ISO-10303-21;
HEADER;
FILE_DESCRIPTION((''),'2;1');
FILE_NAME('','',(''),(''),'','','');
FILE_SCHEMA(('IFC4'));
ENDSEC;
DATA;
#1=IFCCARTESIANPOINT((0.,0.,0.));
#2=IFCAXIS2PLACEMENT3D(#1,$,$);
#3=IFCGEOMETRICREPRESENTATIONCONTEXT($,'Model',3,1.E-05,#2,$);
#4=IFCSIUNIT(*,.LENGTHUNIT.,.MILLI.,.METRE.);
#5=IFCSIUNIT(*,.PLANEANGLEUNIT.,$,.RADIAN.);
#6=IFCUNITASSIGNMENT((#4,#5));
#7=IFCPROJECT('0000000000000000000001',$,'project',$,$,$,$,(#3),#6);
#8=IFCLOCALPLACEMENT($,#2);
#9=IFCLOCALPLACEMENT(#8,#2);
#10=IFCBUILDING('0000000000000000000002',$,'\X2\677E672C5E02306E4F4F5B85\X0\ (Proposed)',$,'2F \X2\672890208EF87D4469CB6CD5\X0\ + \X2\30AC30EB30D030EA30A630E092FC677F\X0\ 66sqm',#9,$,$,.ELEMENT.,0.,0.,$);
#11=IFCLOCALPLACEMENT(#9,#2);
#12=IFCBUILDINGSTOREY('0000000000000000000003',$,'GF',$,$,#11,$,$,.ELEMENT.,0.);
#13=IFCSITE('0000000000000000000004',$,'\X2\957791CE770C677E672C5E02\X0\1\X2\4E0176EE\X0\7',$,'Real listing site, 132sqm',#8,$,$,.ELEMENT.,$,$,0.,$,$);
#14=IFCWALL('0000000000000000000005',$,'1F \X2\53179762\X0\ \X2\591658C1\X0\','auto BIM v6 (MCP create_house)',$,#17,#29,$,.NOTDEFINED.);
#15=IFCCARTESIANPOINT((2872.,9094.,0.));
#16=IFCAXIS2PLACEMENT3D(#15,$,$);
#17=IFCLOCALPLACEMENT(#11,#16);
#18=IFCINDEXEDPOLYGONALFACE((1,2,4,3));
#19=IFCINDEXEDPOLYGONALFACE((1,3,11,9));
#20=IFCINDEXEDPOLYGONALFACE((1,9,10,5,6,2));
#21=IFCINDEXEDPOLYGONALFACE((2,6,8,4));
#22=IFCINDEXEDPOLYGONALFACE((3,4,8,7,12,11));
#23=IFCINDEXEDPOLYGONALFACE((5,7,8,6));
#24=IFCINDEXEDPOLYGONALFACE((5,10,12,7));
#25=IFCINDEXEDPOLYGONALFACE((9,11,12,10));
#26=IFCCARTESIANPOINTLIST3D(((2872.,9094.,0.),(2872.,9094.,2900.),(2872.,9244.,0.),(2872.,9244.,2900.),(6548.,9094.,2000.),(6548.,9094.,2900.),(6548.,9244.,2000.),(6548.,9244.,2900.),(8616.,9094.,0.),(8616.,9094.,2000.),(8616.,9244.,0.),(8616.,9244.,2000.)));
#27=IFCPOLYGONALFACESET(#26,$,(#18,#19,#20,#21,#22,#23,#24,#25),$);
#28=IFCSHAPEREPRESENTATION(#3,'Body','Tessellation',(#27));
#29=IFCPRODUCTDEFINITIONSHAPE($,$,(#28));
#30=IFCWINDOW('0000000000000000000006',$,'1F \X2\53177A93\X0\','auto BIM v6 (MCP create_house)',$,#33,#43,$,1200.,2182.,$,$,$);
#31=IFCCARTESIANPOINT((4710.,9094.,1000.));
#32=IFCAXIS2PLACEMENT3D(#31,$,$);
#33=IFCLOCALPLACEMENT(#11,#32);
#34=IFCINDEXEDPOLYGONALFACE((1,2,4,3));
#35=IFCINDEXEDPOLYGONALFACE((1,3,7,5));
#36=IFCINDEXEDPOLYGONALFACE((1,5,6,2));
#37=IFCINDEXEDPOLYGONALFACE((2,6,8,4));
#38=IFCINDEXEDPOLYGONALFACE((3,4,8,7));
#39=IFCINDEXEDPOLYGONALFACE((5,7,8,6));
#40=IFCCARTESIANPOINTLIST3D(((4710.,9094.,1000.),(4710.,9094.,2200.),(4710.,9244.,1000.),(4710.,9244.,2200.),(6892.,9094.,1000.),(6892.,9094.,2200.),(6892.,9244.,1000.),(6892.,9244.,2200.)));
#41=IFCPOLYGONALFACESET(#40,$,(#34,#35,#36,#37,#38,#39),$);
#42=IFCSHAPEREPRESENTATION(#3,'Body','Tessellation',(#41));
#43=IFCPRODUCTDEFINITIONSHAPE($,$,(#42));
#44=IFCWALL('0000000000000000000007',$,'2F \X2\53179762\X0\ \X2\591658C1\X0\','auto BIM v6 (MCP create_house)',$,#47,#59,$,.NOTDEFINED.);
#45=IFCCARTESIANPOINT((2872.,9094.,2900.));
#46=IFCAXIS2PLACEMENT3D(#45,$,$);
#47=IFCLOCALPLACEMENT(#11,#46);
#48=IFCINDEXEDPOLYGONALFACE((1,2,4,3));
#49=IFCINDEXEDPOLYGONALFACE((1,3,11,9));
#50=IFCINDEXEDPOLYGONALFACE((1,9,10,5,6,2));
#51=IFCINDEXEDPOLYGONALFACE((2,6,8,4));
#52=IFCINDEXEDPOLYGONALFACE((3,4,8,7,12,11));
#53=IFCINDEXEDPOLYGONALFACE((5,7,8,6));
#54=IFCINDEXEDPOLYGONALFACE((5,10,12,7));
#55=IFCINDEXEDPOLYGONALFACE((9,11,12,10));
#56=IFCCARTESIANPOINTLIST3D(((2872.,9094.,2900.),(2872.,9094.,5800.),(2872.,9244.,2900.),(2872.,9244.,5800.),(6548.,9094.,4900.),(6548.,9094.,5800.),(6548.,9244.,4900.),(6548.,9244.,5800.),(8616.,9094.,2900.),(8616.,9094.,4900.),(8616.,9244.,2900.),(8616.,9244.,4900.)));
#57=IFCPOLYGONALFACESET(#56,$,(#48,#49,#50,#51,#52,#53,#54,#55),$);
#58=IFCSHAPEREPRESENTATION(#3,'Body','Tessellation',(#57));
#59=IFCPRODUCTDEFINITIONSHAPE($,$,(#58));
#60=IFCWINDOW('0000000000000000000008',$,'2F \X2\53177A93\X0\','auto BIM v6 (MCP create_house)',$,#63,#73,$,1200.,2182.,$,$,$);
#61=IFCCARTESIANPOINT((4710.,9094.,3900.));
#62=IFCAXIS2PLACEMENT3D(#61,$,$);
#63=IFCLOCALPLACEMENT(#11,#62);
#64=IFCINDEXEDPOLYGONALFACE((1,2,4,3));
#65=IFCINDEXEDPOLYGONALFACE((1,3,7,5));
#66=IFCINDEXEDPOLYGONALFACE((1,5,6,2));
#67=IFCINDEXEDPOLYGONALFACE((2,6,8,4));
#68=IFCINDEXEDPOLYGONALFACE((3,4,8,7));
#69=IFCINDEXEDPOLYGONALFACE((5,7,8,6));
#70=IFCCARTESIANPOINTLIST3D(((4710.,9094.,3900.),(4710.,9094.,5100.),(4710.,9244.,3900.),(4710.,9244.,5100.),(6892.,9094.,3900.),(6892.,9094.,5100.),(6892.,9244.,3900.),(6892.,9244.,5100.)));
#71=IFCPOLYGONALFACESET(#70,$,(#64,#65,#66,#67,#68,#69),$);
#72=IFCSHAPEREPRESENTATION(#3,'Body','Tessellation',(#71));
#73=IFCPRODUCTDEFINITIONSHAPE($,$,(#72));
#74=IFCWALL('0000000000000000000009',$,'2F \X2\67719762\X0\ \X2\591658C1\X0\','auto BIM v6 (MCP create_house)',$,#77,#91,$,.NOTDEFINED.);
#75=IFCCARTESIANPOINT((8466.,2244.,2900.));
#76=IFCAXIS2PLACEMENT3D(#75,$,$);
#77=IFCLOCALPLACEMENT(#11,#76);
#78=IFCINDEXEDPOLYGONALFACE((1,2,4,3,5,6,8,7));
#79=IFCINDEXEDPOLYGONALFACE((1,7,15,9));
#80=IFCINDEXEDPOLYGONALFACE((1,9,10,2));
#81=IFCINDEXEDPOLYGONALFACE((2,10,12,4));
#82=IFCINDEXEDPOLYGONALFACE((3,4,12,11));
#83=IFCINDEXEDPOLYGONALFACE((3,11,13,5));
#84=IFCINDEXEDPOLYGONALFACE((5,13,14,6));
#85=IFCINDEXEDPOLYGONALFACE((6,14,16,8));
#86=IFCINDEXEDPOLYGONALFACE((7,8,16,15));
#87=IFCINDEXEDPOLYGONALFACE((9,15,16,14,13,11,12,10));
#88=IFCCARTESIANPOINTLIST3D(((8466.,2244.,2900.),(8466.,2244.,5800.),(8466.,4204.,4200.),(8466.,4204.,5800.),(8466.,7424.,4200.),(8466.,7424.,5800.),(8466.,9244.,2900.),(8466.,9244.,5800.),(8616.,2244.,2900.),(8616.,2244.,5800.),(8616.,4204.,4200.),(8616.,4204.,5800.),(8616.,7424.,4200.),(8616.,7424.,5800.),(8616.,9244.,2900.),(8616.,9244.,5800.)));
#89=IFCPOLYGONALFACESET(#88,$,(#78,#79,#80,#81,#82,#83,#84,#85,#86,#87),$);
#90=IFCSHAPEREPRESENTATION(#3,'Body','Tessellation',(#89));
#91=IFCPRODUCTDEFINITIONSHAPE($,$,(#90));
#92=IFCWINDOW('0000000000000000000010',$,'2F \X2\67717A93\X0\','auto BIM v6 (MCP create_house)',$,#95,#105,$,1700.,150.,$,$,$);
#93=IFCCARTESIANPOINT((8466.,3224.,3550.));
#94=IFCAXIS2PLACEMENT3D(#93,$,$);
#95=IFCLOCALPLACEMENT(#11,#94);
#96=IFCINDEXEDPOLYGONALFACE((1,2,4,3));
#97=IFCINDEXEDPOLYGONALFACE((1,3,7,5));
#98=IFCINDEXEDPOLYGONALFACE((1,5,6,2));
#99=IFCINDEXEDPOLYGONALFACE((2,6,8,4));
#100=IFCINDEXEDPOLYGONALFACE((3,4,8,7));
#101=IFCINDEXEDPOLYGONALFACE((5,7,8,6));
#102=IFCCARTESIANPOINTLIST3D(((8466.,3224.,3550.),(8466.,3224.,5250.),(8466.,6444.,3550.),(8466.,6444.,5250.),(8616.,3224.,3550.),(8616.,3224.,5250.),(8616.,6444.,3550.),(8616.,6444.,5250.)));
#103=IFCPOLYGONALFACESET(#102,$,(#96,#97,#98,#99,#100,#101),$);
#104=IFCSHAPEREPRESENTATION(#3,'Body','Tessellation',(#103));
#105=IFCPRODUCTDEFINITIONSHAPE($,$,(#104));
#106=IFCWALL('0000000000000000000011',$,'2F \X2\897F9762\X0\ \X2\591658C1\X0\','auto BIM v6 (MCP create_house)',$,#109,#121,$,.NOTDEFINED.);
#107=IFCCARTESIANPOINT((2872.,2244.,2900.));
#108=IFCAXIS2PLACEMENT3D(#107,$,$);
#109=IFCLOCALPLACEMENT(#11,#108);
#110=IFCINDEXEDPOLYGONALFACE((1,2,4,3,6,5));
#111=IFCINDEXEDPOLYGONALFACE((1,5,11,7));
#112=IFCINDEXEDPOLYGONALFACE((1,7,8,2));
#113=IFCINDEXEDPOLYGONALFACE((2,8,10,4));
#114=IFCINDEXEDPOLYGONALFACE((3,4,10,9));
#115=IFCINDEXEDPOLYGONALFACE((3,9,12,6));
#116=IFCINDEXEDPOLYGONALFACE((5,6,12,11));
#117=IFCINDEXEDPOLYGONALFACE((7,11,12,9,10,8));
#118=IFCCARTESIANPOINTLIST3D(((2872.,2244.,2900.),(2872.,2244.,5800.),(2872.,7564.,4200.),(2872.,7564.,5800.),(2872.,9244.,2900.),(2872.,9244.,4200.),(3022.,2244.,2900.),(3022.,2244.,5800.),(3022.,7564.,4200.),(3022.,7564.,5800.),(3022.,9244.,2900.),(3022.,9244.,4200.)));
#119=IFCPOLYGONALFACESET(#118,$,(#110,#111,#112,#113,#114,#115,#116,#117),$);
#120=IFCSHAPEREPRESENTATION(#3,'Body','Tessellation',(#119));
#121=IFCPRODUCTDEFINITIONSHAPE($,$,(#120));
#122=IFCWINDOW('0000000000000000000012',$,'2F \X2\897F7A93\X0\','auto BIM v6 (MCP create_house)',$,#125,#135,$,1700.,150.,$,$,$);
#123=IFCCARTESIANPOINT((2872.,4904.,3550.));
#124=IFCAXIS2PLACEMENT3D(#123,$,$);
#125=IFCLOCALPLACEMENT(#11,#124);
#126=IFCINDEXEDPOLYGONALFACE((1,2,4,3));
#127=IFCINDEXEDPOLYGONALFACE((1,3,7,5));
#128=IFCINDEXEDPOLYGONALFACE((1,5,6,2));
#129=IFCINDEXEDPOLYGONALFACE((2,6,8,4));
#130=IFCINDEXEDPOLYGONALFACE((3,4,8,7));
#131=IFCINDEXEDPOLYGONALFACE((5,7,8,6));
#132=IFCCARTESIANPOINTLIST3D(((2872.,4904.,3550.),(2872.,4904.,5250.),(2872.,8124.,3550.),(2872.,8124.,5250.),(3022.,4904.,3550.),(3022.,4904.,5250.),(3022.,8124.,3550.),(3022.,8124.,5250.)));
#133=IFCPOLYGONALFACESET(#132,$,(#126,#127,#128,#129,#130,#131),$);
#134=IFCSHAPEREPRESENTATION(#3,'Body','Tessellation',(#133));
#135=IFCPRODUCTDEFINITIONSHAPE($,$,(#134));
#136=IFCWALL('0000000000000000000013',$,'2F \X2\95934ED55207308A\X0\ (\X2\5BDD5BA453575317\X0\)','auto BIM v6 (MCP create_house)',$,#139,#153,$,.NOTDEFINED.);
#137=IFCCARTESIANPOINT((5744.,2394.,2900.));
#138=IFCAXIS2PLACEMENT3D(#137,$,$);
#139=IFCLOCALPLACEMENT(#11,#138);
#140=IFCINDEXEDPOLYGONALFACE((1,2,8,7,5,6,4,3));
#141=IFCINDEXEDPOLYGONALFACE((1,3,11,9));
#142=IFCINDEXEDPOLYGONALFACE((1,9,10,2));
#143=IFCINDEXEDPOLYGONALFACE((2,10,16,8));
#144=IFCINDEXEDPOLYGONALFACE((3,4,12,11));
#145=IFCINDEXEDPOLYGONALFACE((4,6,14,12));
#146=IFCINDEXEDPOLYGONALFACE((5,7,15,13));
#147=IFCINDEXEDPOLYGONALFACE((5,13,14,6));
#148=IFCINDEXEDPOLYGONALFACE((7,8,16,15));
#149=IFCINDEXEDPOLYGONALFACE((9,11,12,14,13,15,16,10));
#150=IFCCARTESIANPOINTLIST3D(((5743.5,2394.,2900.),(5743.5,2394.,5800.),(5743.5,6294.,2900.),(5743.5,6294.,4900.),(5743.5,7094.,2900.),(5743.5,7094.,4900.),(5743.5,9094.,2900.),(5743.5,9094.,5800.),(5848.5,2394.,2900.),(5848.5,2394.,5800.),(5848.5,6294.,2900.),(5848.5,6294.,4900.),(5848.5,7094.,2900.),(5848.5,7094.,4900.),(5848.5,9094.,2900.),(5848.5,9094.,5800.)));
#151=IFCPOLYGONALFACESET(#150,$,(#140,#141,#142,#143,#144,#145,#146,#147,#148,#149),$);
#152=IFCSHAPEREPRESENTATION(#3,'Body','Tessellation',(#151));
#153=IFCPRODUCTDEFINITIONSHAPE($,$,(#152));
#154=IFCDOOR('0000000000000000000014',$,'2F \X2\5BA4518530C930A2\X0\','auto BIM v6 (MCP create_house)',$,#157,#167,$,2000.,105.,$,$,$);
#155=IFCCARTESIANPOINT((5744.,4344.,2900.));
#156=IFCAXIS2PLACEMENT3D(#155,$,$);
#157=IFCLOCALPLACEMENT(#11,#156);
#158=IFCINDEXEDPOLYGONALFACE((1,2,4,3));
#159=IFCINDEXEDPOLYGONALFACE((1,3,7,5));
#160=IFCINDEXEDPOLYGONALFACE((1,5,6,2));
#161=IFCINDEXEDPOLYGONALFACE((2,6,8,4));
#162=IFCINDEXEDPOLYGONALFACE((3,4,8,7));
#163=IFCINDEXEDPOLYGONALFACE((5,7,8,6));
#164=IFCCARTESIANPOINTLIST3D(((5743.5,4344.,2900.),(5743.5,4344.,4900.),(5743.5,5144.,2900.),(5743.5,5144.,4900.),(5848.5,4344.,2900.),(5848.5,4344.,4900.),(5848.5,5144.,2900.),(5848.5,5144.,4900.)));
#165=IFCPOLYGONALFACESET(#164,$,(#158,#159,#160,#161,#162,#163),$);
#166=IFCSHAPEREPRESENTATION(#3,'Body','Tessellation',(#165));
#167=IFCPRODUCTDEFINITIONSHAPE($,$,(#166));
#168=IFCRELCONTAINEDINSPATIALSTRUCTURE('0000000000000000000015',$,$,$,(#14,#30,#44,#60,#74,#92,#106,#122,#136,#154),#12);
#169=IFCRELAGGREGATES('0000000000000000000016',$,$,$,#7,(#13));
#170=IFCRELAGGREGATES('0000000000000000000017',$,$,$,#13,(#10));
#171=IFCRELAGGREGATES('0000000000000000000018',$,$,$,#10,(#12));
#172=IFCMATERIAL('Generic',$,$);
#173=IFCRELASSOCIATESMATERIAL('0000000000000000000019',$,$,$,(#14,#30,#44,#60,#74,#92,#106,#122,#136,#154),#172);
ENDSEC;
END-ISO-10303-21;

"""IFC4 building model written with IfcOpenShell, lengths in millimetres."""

from ifc_helpers import new_model, si_unit, frame, frame_2d, origin, place, context, project, spatial, rectangle, extrude, material, element, fill, save


model = new_model("IFC4")

# Units and contexts
model_context = context("Model", 3, precision=1e-05, world=origin())
ifc_project = project(units=[si_unit("LENGTHUNIT", "METRE", prefix="MILLI"), si_unit("PLANEANGLEUNIT", "RADIAN")], contexts=[model_context])

# Site, building, storey
site_placement = place(None, origin())
site = spatial("IfcSite", under=ifc_project, at=site_placement, Name="長野県松本市1丁目7", ObjectType="Real listing site, 132sqm", CompositionType="ELEMENT", RefElevation=0.0)
building_placement = place(site_placement, origin())
building = spatial("IfcBuilding", under=site, at=building_placement, Name="松本市の住宅 (Proposed)", ObjectType="2F 木造軸組構法 + ガルバリウム鋼板 66sqm", CompositionType="ELEMENT", ElevationOfRefHeight=0.0, ElevationOfTerrain=0.0)
storey_placement = place(building_placement, origin())
storey = spatial("IfcBuildingStorey", under=building, at=storey_placement, Name="GF", CompositionType="ELEMENT", Elevation=0.0)

# Wall, opening, window
ifc_material = material(Name="Generic")
wall_1_placement = place(storey_placement, frame((2872.0, 9094.0, 0.0)))
wall_1 = element("IfcWall", 1, at=wall_1_placement, inside=storey, material=ifc_material, Name="1F 北面 外壁", Description="auto BIM v6 (MCP create_house)", PredefinedType="NOTDEFINED", context=model_context, shape_type="SweptSolid", body=[
    extrude(rectangle(XDim=5744.0, YDim=150.0, at=frame_2d((2872.0, 75.0))), frame((2872.0, 9094.0, 0.0)), (0.0, 0.0, 1.0), 2900.0),
])
opening_1_placement = place(storey_placement, frame((4710.0, 9094.0, 1000.0)))
opening_1 = element("IfcOpeningElement", 2, at=opening_1_placement, cuts=wall_1, PredefinedType="NOTDEFINED", context=model_context, shape_type="SweptSolid", body=[
    extrude(rectangle(XDim=2182.0, YDim=150.0, at=frame_2d((1091.0, 75.0))), frame((4710.0, 9094.0, 1000.0)), (0.0, 0.0, 1.0), 1200.0),
])
window_1_placement = place(storey_placement, frame((4710.0, 9094.0, 1000.0)))
window_1 = element("IfcWindow", 3, at=window_1_placement, inside=storey, material=ifc_material, Name="1F 北窓", Description="auto BIM v6 (MCP create_house)", OverallHeight=1200.0, OverallWidth=2182.0, context=model_context, shape_type="SweptSolid", body=[
    extrude(rectangle(XDim=2182.0, YDim=150.0, at=frame_2d((1091.0, 75.0))), frame((4710.0, 9094.0, 1000.0)), (0.0, 0.0, 1.0), 1200.0),
])
fill(opening_1, window_1)

# Walls, openings, windows
wall_2_placement = place(storey_placement, frame((2872.0, 9094.0, 2900.0)))
wall_2 = element("IfcWall", 4, at=wall_2_placement, inside=storey, material=ifc_material, Name="2F 北面 外壁", Description="auto BIM v6 (MCP create_house)", PredefinedType="NOTDEFINED", context=model_context, shape_type="SweptSolid", body=[
    extrude(rectangle(XDim=5744.0, YDim=150.0, at=frame_2d((2872.0, 75.0))), frame((2872.0, 9094.0, 2900.0)), (0.0, 0.0, 1.0), 2900.0),
])
opening_2_placement = place(storey_placement, frame((4710.0, 9094.0, 3900.0)))
opening_2 = element("IfcOpeningElement", 5, at=opening_2_placement, cuts=wall_2, PredefinedType="NOTDEFINED", context=model_context, shape_type="SweptSolid", body=[
    extrude(rectangle(XDim=2182.0, YDim=150.0, at=frame_2d((1091.0, 75.0))), frame((4710.0, 9094.0, 3900.0)), (0.0, 0.0, 1.0), 1200.0),
])
window_2_placement = place(storey_placement, frame((4710.0, 9094.0, 3900.0)))
window_2 = element("IfcWindow", 6, at=window_2_placement, inside=storey, material=ifc_material, Name="2F 北窓", Description="auto BIM v6 (MCP create_house)", OverallHeight=1200.0, OverallWidth=2182.0, context=model_context, shape_type="SweptSolid", body=[
    extrude(rectangle(XDim=2182.0, YDim=150.0, at=frame_2d((1091.0, 75.0))), frame((4710.0, 9094.0, 3900.0)), (0.0, 0.0, 1.0), 1200.0),
])
fill(opening_2, window_2)
wall_3_placement = place(storey_placement, frame((8466.0, 2244.0, 2900.0)))
wall_3 = element("IfcWall", 7, at=wall_3_placement, inside=storey, material=ifc_material, Name="2F 東面 外壁", Description="auto BIM v6 (MCP create_house)", PredefinedType="NOTDEFINED", context=model_context, shape_type="SweptSolid", body=[
    extrude(rectangle(XDim=150.0, YDim=7000.0, at=frame_2d((75.0, 3500.0))), frame((8466.0, 2244.0, 2900.0)), (0.0, 0.0, 1.0), 2900.0),
])
opening_3_placement = place(storey_placement, frame((8466.0, 3224.0, 3550.0)))
opening_3 = element("IfcOpeningElement", 8, at=opening_3_placement, cuts=wall_3, PredefinedType="NOTDEFINED", context=model_context, shape_type="SweptSolid", body=[
    extrude(rectangle(XDim=150.0, YDim=3220.0, at=frame_2d((75.0, 1610.0))), frame((8466.0, 3224.0, 3550.0)), (0.0, 0.0, 1.0), 1700.0),
])
window_3_placement = place(storey_placement, frame((8466.0, 3224.0, 3550.0)))
window_3 = element("IfcWindow", 9, at=window_3_placement, inside=storey, material=ifc_material, Name="2F 東窓", Description="auto BIM v6 (MCP create_house)", OverallHeight=1700.0, OverallWidth=150.0, context=model_context, shape_type="SweptSolid", body=[
    extrude(rectangle(XDim=150.0, YDim=3220.0, at=frame_2d((75.0, 1610.0))), frame((8466.0, 3224.0, 3550.0)), (0.0, 0.0, 1.0), 1700.0),
])
fill(opening_3, window_3)
wall_4_placement = place(storey_placement, frame((2872.0, 2244.0, 2900.0)))
wall_4 = element("IfcWall", 10, at=wall_4_placement, inside=storey, material=ifc_material, Name="2F 西面 外壁", Description="auto BIM v6 (MCP create_house)", PredefinedType="NOTDEFINED", context=model_context, shape_type="SweptSolid", body=[
    extrude(rectangle(XDim=150.0, YDim=7000.0, at=frame_2d((75.0, 3500.0))), frame((2872.0, 2244.0, 2900.0)), (0.0, 0.0, 1.0), 2900.0),
])
opening_4_placement = place(storey_placement, frame((2872.0, 4904.0, 3550.0)))
opening_4 = element("IfcOpeningElement", 11, at=opening_4_placement, cuts=wall_4, PredefinedType="NOTDEFINED", context=model_context, shape_type="SweptSolid", body=[
    extrude(rectangle(XDim=150.0, YDim=3220.0, at=frame_2d((75.0, 1610.0))), frame((2872.0, 4904.0, 3550.0)), (0.0, 0.0, 1.0), 1700.0),
])
window_4_placement = place(storey_placement, frame((2872.0, 4904.0, 3550.0)))
window_4 = element("IfcWindow", 12, at=window_4_placement, inside=storey, material=ifc_material, Name="2F 西窓", Description="auto BIM v6 (MCP create_house)", OverallHeight=1700.0, OverallWidth=150.0, context=model_context, shape_type="SweptSolid", body=[
    extrude(rectangle(XDim=150.0, YDim=3220.0, at=frame_2d((75.0, 1610.0))), frame((2872.0, 4904.0, 3550.0)), (0.0, 0.0, 1.0), 1700.0),
])
fill(opening_4, window_4)

# Wall, opening, door
wall_5_placement = place(storey_placement, frame((5744.0, 2394.0, 2900.0)))
wall_5 = element("IfcWall", 13, at=wall_5_placement, inside=storey, material=ifc_material, Name="2F 間仕切り (寝室南北)", Description="auto BIM v6 (MCP create_house)", PredefinedType="NOTDEFINED", context=model_context, shape_type="SweptSolid", body=[
    extrude(rectangle(XDim=105.0, YDim=6700.0, at=frame_2d((52.0, 3350.0))), frame((5744.0, 2394.0, 2900.0)), (0.0, 0.0, 1.0), 2900.0),
])
opening_5_placement = place(storey_placement, frame((5744.0, 4344.0, 2900.0)))
opening_5 = element("IfcOpeningElement", 14, at=opening_5_placement, cuts=wall_5, PredefinedType="NOTDEFINED", context=model_context, shape_type="SweptSolid", body=[
    extrude(rectangle(XDim=105.0, YDim=800.0, at=frame_2d((52.0, 400.0))), frame((5744.0, 4344.0, 2900.0)), (0.0, 0.0, 1.0), 2000.0),
])
door_placement = place(storey_placement, frame((5744.0, 4344.0, 2900.0)))
door = element("IfcDoor", 15, at=door_placement, inside=storey, material=ifc_material, Name="2F 室内ドア", Description="auto BIM v6 (MCP create_house)", OverallHeight=2000.0, OverallWidth=105.0, context=model_context, shape_type="SweptSolid", body=[
    extrude(rectangle(XDim=105.0, YDim=800.0, at=frame_2d((52.0, 400.0))), frame((5744.0, 4344.0, 2900.0)), (0.0, 0.0, 1.0), 2000.0),
])
fill(opening_5, door)

save(model, "model.ifc")
